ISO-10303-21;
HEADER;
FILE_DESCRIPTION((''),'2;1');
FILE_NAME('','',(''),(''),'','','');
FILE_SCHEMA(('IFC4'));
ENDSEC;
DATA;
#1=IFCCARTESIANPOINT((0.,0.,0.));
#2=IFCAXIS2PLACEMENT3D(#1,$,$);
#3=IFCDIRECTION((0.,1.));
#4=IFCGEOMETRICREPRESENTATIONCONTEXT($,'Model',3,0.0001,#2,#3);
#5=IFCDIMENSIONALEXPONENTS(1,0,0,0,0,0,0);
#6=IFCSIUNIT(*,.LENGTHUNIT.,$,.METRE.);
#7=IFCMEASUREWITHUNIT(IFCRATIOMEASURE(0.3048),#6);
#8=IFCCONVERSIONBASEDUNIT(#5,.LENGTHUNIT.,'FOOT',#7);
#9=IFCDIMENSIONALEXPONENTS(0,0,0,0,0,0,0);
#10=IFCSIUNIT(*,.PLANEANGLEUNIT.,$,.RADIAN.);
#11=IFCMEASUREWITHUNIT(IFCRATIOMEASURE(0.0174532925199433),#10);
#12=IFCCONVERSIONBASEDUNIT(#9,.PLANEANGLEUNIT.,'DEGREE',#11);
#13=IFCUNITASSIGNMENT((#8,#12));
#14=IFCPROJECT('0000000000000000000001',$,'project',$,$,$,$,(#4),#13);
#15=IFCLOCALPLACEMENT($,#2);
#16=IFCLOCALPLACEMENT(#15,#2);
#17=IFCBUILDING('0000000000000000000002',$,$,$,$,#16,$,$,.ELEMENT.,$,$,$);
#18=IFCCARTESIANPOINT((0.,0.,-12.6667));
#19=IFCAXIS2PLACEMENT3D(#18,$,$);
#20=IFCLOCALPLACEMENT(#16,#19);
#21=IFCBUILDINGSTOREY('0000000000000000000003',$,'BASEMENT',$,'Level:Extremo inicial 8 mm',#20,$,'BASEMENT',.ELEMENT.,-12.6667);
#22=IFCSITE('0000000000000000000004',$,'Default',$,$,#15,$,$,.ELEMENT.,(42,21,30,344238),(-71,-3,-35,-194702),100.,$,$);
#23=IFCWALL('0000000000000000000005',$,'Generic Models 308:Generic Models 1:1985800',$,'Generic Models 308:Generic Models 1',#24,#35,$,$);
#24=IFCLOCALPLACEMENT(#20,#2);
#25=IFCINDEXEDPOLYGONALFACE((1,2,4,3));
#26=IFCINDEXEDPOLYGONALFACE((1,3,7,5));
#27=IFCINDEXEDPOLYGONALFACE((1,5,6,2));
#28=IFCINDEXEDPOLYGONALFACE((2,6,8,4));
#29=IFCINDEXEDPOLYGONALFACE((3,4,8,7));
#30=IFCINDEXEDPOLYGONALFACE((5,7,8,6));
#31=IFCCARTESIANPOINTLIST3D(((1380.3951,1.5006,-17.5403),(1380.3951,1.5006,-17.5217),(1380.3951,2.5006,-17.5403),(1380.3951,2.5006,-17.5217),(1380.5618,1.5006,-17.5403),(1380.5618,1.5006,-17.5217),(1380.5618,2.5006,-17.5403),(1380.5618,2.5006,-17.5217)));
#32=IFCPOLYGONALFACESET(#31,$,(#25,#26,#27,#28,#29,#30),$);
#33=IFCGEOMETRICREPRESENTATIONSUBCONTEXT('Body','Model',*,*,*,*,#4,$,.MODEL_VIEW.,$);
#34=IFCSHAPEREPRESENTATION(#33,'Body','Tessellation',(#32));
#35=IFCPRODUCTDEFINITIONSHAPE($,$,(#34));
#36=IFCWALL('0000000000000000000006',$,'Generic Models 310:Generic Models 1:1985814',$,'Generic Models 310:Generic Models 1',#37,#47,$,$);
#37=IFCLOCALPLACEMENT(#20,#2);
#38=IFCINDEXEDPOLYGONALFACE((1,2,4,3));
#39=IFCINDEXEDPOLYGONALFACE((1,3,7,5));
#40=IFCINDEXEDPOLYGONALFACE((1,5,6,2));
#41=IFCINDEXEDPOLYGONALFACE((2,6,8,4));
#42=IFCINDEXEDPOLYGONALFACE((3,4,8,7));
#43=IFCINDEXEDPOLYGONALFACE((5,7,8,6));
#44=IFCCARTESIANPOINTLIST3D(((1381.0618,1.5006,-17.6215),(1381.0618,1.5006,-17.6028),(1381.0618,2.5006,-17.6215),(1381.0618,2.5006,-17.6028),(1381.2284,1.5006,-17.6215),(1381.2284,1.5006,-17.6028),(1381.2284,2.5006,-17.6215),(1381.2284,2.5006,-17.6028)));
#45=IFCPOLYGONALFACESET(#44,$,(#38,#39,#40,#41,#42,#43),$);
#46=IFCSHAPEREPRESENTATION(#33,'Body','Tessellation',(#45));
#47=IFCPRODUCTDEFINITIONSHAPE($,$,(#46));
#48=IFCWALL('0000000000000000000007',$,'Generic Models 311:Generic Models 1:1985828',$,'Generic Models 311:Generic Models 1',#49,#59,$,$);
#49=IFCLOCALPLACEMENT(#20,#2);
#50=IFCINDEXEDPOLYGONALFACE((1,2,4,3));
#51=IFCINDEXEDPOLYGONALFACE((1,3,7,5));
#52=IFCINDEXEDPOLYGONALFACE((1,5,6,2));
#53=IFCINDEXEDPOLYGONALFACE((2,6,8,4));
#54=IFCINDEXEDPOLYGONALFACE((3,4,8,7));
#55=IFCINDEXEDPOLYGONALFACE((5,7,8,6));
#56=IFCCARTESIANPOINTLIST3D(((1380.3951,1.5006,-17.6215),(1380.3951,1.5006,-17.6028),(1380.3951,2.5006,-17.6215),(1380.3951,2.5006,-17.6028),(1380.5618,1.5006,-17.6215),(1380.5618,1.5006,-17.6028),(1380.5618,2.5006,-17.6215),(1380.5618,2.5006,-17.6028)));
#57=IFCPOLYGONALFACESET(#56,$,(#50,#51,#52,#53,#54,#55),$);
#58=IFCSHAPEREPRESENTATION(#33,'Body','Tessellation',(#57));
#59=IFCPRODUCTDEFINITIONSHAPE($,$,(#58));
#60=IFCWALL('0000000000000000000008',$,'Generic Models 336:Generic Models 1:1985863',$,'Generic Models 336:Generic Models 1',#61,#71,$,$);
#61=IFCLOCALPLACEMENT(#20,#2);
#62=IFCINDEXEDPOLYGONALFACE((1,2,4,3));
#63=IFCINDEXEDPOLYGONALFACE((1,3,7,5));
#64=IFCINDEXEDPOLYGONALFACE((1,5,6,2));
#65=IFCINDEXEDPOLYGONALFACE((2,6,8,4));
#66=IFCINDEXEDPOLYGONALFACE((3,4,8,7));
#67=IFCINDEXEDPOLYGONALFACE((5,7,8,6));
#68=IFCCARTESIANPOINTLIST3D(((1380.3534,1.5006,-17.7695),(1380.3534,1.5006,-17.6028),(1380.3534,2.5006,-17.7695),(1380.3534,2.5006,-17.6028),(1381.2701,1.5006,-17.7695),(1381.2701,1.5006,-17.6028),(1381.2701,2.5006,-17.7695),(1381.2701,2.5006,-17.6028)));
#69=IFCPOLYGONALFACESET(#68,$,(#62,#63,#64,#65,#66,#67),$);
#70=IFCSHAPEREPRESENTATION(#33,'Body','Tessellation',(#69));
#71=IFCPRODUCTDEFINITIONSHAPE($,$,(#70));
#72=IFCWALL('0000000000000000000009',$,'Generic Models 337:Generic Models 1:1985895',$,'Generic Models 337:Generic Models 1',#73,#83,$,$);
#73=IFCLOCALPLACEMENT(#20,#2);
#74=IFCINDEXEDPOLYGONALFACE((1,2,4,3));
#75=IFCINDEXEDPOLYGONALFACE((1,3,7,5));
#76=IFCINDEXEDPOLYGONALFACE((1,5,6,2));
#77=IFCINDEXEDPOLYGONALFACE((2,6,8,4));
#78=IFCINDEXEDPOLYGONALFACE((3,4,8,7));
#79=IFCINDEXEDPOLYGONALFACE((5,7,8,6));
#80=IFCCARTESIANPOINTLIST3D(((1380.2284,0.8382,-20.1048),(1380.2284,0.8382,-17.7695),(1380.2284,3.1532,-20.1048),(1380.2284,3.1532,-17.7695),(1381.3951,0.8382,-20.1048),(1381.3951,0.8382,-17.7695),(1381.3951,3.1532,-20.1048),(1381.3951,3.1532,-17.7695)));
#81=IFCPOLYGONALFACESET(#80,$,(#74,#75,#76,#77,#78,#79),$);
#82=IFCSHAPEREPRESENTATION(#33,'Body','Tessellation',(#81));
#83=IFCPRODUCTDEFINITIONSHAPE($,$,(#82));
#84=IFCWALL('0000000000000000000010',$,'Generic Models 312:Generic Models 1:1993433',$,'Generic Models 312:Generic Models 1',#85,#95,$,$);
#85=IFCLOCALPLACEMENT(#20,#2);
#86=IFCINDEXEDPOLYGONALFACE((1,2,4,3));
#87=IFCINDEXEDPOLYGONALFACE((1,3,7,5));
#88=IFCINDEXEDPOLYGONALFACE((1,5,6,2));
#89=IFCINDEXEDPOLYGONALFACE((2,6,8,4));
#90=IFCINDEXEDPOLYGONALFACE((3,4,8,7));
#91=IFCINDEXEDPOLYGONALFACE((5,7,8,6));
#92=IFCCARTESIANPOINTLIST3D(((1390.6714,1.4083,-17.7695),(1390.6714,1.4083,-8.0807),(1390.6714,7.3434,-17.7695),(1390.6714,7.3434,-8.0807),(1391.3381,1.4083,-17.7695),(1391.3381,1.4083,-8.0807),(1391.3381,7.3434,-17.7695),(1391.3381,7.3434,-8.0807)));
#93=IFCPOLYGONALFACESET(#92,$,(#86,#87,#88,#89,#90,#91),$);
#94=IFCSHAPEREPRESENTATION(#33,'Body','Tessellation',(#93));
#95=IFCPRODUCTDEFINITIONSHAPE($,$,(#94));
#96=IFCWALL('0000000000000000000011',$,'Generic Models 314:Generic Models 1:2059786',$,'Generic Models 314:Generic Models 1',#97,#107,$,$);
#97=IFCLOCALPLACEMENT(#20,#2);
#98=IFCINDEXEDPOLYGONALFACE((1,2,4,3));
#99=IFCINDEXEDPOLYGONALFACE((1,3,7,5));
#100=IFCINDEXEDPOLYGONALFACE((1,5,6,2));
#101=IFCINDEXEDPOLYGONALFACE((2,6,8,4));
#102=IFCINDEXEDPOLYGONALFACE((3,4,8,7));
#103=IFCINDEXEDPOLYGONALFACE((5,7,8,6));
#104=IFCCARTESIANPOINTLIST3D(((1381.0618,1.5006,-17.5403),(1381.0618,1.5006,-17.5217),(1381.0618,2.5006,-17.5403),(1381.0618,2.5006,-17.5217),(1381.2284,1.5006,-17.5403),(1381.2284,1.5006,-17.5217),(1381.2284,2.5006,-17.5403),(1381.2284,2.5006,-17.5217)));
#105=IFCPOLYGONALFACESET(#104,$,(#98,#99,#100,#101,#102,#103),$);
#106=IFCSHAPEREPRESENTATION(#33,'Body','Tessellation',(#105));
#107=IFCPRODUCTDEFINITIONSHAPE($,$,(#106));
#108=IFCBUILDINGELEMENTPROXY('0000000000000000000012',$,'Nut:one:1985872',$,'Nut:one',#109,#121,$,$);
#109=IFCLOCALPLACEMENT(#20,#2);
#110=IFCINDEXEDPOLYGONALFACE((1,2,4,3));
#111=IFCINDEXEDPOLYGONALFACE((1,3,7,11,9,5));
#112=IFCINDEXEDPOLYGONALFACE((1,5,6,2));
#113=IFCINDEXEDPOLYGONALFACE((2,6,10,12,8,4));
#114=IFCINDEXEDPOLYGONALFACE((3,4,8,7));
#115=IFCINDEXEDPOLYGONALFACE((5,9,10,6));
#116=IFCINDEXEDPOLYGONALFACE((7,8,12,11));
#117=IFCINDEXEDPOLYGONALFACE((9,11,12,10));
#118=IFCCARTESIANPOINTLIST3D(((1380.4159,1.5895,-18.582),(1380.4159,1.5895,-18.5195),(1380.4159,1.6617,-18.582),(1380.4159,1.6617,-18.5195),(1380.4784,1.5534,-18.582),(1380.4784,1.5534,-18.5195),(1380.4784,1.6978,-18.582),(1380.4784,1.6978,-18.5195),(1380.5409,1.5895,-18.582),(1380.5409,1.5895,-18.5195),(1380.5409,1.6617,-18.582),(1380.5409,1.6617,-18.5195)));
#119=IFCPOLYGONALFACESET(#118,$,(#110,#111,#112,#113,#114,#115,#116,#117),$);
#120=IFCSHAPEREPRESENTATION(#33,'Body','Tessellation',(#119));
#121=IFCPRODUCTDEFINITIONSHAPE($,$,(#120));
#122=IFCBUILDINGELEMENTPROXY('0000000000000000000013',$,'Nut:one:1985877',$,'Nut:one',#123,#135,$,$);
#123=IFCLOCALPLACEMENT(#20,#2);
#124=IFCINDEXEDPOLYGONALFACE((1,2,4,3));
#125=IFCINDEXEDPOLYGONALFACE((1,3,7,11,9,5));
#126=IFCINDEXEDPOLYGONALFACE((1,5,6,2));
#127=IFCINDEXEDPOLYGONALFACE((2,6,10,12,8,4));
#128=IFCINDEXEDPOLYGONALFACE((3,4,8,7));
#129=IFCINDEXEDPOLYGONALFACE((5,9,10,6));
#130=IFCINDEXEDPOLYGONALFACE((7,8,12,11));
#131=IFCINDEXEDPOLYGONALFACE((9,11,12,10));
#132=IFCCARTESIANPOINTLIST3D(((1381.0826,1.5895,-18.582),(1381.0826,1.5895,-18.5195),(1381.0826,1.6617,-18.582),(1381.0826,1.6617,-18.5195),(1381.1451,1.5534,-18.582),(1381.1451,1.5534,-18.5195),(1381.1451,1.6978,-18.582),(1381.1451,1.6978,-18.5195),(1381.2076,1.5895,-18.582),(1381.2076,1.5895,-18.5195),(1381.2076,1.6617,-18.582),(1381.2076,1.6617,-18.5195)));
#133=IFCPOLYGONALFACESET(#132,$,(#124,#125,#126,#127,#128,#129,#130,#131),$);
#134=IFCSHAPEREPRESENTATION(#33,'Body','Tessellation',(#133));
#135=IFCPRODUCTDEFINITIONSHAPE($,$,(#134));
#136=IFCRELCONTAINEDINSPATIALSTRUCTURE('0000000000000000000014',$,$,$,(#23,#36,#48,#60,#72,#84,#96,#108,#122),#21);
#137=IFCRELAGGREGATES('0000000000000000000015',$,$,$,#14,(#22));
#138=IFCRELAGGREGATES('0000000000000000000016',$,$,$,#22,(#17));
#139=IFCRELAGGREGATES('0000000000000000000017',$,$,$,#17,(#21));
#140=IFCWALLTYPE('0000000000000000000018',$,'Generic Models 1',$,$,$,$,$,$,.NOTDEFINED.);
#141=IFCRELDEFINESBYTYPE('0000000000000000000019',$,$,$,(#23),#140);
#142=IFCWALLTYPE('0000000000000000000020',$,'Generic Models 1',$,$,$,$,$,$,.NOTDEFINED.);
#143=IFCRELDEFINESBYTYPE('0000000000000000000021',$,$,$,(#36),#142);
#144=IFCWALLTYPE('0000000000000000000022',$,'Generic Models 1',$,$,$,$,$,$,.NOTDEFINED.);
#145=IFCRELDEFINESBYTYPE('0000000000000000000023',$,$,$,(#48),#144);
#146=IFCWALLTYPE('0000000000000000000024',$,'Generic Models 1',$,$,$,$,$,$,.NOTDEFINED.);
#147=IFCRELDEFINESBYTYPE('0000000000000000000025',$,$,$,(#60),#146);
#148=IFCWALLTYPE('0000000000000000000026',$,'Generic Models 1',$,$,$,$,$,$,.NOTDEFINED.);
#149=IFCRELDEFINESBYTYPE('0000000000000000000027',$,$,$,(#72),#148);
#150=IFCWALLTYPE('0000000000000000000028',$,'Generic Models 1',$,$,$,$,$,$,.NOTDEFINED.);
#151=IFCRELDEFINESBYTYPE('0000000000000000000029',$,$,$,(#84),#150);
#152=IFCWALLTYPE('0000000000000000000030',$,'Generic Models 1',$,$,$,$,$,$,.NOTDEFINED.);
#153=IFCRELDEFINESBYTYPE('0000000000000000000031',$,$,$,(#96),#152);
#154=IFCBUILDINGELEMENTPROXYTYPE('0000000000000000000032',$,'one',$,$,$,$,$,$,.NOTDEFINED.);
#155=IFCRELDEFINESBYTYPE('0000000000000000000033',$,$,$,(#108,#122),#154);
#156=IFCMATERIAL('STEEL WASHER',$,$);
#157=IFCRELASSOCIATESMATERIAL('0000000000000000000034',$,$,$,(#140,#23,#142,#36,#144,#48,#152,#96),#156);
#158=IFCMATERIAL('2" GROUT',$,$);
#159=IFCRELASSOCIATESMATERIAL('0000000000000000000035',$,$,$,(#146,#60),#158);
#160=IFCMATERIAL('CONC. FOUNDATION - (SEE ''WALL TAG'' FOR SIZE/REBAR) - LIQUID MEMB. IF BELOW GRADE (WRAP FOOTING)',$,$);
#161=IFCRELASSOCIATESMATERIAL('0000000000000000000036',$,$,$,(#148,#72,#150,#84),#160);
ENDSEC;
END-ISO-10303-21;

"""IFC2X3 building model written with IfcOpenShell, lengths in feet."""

from ifc_helpers import new_model, entity, si_unit, converted_unit, direction, frame, frame_2d, origin, origin_2d_with_axis, place, context, subcontext, project, spatial, polyline, rectangle, outline, extrude, source, transform, mapped, material, type_object, type_shapes, element, save


model = new_model("IFC2X3")

# Units and contexts
model_context = context("Model", 3, precision=0.0001, world=origin(), true_north=direction((0.0, 1.0)))
body_context = subcontext(model_context, "Body", "Model", "MODEL_VIEW")
ifc_project = project(units=[converted_unit("LENGTHUNIT", "FOOT", entity("IfcRatioMeasure", 0.3048), si_unit("LENGTHUNIT", "METRE"), dimensions=[1, 0, 0, 0, 0, 0, 0]), converted_unit("PLANEANGLEUNIT", "DEGREE", entity("IfcRatioMeasure", 0.0174532925199433), si_unit("PLANEANGLEUNIT", "RADIAN"), dimensions=[0, 0, 0, 0, 0, 0, 0])], contexts=[model_context])

# Site, building, storey
site_placement = place(None, origin())
site = spatial("IfcSite", under=ifc_project, at=site_placement, Name="Default", CompositionType="ELEMENT", RefLatitude=(42, 21, 30, 344238), RefLongitude=(-71, -3, -35, -194702), RefElevation=100.0)
building_placement = place(site_placement, origin())
building = spatial("IfcBuilding", under=site, at=building_placement, CompositionType="ELEMENT")
storey_placement = place(building_placement, frame((0.0, 0.0, -12.6667)))
storey = spatial("IfcBuildingStorey", under=building, at=storey_placement, Name="BASEMENT", ObjectType="Level:Extremo inicial 8 mm", LongName="BASEMENT", CompositionType="ELEMENT", Elevation=-12.6667)

# Walls
ifc_material_1 = material(Name="STEEL WASHER")
wall_type_1 = type_object("IfcWallType", Name="Generic Models 1", PredefinedType="NOTDEFINED", material=ifc_material_1)
wall_1_placement = place(storey_placement, frame((1380.3951, 1.5006, -17.5403), z_axis=(0.0, 0.0, 1.0), x_axis=(0.0, 1.0, 0.0)))
element("IfcWall", 1, at=wall_1_placement, inside=storey, type_object=wall_type_1, material=ifc_material_1, Name="Generic Models 308:Generic Models 1:1985800", ObjectType="Generic Models 308:Generic Models 1", context=body_context, shape_type="SweptSolid", body=[
    extrude(rectangle(XDim=1.0, YDim=0.1667, at=frame_2d((0.0, 0.0), x_axis=(1.0, 0.0))), frame((0.5, -0.0833, 0.0)), (0.0, 0.0, 1.0), 0.0187),
])
wall_type_2 = type_object("IfcWallType", Name="Generic Models 1", PredefinedType="NOTDEFINED", material=ifc_material_1)
wall_2_placement = place(storey_placement, frame((1381.0618, 1.5006, -17.6215), z_axis=(0.0, 0.0, 1.0), x_axis=(0.0, 1.0, 0.0)))
element("IfcWall", 2, at=wall_2_placement, inside=storey, type_object=wall_type_2, material=ifc_material_1, Name="Generic Models 310:Generic Models 1:1985814", ObjectType="Generic Models 310:Generic Models 1", context=body_context, shape_type="SweptSolid", body=[
    extrude(rectangle(XDim=1.0, YDim=0.1667, at=frame_2d((0.0, 0.0), x_axis=(1.0, 0.0))), frame((0.5, -0.0833, 0.0)), (0.0, 0.0, 1.0), 0.0187),
])
wall_type_3 = type_object("IfcWallType", Name="Generic Models 1", PredefinedType="NOTDEFINED", material=ifc_material_1)
wall_3_placement = place(storey_placement, frame((1380.3951, 1.5006, -17.6215), z_axis=(0.0, 0.0, 1.0), x_axis=(0.0, 1.0, 0.0)))
element("IfcWall", 3, at=wall_3_placement, inside=storey, type_object=wall_type_3, material=ifc_material_1, Name="Generic Models 311:Generic Models 1:1985828", ObjectType="Generic Models 311:Generic Models 1", context=body_context, shape_type="SweptSolid", body=[
    extrude(rectangle(XDim=1.0, YDim=0.1667, at=frame_2d((0.0, 0.0), x_axis=(1.0, 0.0))), frame((0.5, -0.0833, 0.0)), (0.0, 0.0, 1.0), 0.0187),
])
ifc_material_2 = material(Name="2\" GROUT")
wall_type_4 = type_object("IfcWallType", Name="Generic Models 1", PredefinedType="NOTDEFINED", material=ifc_material_2)
wall_4_placement = place(storey_placement, frame((1380.3534, 1.5006, -17.7695), z_axis=(0.0, 0.0, 1.0), x_axis=(0.0, 1.0, 0.0)))
element("IfcWall", 4, at=wall_4_placement, inside=storey, type_object=wall_type_4, material=ifc_material_2, Name="Generic Models 336:Generic Models 1:1985863", ObjectType="Generic Models 336:Generic Models 1", context=body_context, shape_type="SweptSolid", body=[
    extrude(rectangle(XDim=1.0, YDim=0.9167, at=frame_2d((0.0, 0.0), x_axis=(1.0, 0.0))), frame((0.5, -0.4583, 0.0)), (0.0, 0.0, 1.0), 0.1667),
])
ifc_material_3 = material(Name="CONC. FOUNDATION - (SEE 'WALL TAG' FOR SIZE/REBAR) - LIQUID MEMB. IF BELOW GRADE (WRAP FOOTING)")
wall_type_5 = type_object("IfcWallType", Name="Generic Models 1", PredefinedType="NOTDEFINED", material=ifc_material_3)
wall_5_placement = place(storey_placement, frame((1380.2284, 0.8382, -20.1048), z_axis=(0.0, 0.0, 1.0), x_axis=(0.0, 1.0, 0.0)))
element("IfcWall", 5, at=wall_5_placement, inside=storey, type_object=wall_type_5, material=ifc_material_3, Name="Generic Models 337:Generic Models 1:1985895", ObjectType="Generic Models 337:Generic Models 1", context=body_context, shape_type="SweptSolid", body=[
    extrude(rectangle(XDim=2.315, YDim=1.1667, at=frame_2d((0.0, 0.0), x_axis=(1.0, 0.0))), frame((1.1575, -0.5833, 0.0)), (0.0, 0.0, 1.0), 2.3353),
])
wall_type_6 = type_object("IfcWallType", Name="Generic Models 1", PredefinedType="NOTDEFINED", material=ifc_material_3)
wall_6_placement = place(storey_placement, frame((1390.6714, 1.4083, -17.7695), z_axis=(0.0, 0.0, 1.0), x_axis=(0.0, 1.0, 0.0)))
element("IfcWall", 6, at=wall_6_placement, inside=storey, type_object=wall_type_6, material=ifc_material_3, Name="Generic Models 312:Generic Models 1:1993433", ObjectType="Generic Models 312:Generic Models 1", context=body_context, shape_type="SweptSolid", body=[
    extrude(rectangle(XDim=5.9351, YDim=0.6667, at=origin_2d_with_axis()), frame((2.9675, -0.3333, 0.0)), (0.0, 0.0, 1.0), 9.6888),
])
wall_type_7 = type_object("IfcWallType", Name="Generic Models 1", PredefinedType="NOTDEFINED", material=ifc_material_1)
wall_7_placement = place(storey_placement, frame((1381.0618, 1.5006, -17.5403), z_axis=(0.0, 0.0, 1.0), x_axis=(0.0, 1.0, 0.0)))
element("IfcWall", 7, at=wall_7_placement, inside=storey, type_object=wall_type_7, material=ifc_material_1, Name="Generic Models 314:Generic Models 1:2059786", ObjectType="Generic Models 314:Generic Models 1", context=body_context, shape_type="SweptSolid", body=[
    extrude(rectangle(XDim=1.0, YDim=0.1667, at=frame_2d((0.0, 0.0), x_axis=(1.0, 0.0))), frame((0.5, -0.0833, 0.0)), (0.0, 0.0, 1.0), 0.0187),
])

# Building element proxies
building_element_proxy_type_1 = type_object("IfcBuildingElementProxyType", Name="one", PredefinedType="NOTDEFINED")
shared_shape_1 = source(origin(), body_context, "Body", "SweptSolid", [
    extrude(outline(polyline([(-0.0361, -0.0625), (0.0361, -0.0625), (0.0722, 0.0), (0.0361, 0.0625), (-0.0361, 0.0625), (-0.0722, 0.0), (-0.0361, -0.0625)])), frame((0.0, 0.0, 0.0), z_axis=(0.0, 0.0, 1.0), x_axis=(0.0, -1.0, 0.0)), (0.0, 0.0, 1.0), 0.0625),
])
type_shapes(building_element_proxy_type_1, [shared_shape_1])
for number, where, z_axis, x_axis, name in (
    (8, (1380.4784, 1.6256, -18.5195), (0.0, 0.0, -1.0), (1.0, 0.0, 0.0), "Nut:one:1985872"),
    (9, (1381.1451, 1.6256, -18.5195), (0.0, 0.0, -1.0), (1.0, 0.0, 0.0), "Nut:one:1985877"),
):
    element("IfcBuildingElementProxy", number, at=place(storey_placement, frame(where, z_axis=z_axis, x_axis=x_axis)), inside=storey, type_object=building_element_proxy_type_1, Name=name, ObjectType="Nut:one", context=body_context, shape_type="MappedRepresentation", body=[
        mapped(shared_shape_1, transform((0.0, 0.0, 0.0), scale=1.0)),
    ])

save(model, "model.ifc")
